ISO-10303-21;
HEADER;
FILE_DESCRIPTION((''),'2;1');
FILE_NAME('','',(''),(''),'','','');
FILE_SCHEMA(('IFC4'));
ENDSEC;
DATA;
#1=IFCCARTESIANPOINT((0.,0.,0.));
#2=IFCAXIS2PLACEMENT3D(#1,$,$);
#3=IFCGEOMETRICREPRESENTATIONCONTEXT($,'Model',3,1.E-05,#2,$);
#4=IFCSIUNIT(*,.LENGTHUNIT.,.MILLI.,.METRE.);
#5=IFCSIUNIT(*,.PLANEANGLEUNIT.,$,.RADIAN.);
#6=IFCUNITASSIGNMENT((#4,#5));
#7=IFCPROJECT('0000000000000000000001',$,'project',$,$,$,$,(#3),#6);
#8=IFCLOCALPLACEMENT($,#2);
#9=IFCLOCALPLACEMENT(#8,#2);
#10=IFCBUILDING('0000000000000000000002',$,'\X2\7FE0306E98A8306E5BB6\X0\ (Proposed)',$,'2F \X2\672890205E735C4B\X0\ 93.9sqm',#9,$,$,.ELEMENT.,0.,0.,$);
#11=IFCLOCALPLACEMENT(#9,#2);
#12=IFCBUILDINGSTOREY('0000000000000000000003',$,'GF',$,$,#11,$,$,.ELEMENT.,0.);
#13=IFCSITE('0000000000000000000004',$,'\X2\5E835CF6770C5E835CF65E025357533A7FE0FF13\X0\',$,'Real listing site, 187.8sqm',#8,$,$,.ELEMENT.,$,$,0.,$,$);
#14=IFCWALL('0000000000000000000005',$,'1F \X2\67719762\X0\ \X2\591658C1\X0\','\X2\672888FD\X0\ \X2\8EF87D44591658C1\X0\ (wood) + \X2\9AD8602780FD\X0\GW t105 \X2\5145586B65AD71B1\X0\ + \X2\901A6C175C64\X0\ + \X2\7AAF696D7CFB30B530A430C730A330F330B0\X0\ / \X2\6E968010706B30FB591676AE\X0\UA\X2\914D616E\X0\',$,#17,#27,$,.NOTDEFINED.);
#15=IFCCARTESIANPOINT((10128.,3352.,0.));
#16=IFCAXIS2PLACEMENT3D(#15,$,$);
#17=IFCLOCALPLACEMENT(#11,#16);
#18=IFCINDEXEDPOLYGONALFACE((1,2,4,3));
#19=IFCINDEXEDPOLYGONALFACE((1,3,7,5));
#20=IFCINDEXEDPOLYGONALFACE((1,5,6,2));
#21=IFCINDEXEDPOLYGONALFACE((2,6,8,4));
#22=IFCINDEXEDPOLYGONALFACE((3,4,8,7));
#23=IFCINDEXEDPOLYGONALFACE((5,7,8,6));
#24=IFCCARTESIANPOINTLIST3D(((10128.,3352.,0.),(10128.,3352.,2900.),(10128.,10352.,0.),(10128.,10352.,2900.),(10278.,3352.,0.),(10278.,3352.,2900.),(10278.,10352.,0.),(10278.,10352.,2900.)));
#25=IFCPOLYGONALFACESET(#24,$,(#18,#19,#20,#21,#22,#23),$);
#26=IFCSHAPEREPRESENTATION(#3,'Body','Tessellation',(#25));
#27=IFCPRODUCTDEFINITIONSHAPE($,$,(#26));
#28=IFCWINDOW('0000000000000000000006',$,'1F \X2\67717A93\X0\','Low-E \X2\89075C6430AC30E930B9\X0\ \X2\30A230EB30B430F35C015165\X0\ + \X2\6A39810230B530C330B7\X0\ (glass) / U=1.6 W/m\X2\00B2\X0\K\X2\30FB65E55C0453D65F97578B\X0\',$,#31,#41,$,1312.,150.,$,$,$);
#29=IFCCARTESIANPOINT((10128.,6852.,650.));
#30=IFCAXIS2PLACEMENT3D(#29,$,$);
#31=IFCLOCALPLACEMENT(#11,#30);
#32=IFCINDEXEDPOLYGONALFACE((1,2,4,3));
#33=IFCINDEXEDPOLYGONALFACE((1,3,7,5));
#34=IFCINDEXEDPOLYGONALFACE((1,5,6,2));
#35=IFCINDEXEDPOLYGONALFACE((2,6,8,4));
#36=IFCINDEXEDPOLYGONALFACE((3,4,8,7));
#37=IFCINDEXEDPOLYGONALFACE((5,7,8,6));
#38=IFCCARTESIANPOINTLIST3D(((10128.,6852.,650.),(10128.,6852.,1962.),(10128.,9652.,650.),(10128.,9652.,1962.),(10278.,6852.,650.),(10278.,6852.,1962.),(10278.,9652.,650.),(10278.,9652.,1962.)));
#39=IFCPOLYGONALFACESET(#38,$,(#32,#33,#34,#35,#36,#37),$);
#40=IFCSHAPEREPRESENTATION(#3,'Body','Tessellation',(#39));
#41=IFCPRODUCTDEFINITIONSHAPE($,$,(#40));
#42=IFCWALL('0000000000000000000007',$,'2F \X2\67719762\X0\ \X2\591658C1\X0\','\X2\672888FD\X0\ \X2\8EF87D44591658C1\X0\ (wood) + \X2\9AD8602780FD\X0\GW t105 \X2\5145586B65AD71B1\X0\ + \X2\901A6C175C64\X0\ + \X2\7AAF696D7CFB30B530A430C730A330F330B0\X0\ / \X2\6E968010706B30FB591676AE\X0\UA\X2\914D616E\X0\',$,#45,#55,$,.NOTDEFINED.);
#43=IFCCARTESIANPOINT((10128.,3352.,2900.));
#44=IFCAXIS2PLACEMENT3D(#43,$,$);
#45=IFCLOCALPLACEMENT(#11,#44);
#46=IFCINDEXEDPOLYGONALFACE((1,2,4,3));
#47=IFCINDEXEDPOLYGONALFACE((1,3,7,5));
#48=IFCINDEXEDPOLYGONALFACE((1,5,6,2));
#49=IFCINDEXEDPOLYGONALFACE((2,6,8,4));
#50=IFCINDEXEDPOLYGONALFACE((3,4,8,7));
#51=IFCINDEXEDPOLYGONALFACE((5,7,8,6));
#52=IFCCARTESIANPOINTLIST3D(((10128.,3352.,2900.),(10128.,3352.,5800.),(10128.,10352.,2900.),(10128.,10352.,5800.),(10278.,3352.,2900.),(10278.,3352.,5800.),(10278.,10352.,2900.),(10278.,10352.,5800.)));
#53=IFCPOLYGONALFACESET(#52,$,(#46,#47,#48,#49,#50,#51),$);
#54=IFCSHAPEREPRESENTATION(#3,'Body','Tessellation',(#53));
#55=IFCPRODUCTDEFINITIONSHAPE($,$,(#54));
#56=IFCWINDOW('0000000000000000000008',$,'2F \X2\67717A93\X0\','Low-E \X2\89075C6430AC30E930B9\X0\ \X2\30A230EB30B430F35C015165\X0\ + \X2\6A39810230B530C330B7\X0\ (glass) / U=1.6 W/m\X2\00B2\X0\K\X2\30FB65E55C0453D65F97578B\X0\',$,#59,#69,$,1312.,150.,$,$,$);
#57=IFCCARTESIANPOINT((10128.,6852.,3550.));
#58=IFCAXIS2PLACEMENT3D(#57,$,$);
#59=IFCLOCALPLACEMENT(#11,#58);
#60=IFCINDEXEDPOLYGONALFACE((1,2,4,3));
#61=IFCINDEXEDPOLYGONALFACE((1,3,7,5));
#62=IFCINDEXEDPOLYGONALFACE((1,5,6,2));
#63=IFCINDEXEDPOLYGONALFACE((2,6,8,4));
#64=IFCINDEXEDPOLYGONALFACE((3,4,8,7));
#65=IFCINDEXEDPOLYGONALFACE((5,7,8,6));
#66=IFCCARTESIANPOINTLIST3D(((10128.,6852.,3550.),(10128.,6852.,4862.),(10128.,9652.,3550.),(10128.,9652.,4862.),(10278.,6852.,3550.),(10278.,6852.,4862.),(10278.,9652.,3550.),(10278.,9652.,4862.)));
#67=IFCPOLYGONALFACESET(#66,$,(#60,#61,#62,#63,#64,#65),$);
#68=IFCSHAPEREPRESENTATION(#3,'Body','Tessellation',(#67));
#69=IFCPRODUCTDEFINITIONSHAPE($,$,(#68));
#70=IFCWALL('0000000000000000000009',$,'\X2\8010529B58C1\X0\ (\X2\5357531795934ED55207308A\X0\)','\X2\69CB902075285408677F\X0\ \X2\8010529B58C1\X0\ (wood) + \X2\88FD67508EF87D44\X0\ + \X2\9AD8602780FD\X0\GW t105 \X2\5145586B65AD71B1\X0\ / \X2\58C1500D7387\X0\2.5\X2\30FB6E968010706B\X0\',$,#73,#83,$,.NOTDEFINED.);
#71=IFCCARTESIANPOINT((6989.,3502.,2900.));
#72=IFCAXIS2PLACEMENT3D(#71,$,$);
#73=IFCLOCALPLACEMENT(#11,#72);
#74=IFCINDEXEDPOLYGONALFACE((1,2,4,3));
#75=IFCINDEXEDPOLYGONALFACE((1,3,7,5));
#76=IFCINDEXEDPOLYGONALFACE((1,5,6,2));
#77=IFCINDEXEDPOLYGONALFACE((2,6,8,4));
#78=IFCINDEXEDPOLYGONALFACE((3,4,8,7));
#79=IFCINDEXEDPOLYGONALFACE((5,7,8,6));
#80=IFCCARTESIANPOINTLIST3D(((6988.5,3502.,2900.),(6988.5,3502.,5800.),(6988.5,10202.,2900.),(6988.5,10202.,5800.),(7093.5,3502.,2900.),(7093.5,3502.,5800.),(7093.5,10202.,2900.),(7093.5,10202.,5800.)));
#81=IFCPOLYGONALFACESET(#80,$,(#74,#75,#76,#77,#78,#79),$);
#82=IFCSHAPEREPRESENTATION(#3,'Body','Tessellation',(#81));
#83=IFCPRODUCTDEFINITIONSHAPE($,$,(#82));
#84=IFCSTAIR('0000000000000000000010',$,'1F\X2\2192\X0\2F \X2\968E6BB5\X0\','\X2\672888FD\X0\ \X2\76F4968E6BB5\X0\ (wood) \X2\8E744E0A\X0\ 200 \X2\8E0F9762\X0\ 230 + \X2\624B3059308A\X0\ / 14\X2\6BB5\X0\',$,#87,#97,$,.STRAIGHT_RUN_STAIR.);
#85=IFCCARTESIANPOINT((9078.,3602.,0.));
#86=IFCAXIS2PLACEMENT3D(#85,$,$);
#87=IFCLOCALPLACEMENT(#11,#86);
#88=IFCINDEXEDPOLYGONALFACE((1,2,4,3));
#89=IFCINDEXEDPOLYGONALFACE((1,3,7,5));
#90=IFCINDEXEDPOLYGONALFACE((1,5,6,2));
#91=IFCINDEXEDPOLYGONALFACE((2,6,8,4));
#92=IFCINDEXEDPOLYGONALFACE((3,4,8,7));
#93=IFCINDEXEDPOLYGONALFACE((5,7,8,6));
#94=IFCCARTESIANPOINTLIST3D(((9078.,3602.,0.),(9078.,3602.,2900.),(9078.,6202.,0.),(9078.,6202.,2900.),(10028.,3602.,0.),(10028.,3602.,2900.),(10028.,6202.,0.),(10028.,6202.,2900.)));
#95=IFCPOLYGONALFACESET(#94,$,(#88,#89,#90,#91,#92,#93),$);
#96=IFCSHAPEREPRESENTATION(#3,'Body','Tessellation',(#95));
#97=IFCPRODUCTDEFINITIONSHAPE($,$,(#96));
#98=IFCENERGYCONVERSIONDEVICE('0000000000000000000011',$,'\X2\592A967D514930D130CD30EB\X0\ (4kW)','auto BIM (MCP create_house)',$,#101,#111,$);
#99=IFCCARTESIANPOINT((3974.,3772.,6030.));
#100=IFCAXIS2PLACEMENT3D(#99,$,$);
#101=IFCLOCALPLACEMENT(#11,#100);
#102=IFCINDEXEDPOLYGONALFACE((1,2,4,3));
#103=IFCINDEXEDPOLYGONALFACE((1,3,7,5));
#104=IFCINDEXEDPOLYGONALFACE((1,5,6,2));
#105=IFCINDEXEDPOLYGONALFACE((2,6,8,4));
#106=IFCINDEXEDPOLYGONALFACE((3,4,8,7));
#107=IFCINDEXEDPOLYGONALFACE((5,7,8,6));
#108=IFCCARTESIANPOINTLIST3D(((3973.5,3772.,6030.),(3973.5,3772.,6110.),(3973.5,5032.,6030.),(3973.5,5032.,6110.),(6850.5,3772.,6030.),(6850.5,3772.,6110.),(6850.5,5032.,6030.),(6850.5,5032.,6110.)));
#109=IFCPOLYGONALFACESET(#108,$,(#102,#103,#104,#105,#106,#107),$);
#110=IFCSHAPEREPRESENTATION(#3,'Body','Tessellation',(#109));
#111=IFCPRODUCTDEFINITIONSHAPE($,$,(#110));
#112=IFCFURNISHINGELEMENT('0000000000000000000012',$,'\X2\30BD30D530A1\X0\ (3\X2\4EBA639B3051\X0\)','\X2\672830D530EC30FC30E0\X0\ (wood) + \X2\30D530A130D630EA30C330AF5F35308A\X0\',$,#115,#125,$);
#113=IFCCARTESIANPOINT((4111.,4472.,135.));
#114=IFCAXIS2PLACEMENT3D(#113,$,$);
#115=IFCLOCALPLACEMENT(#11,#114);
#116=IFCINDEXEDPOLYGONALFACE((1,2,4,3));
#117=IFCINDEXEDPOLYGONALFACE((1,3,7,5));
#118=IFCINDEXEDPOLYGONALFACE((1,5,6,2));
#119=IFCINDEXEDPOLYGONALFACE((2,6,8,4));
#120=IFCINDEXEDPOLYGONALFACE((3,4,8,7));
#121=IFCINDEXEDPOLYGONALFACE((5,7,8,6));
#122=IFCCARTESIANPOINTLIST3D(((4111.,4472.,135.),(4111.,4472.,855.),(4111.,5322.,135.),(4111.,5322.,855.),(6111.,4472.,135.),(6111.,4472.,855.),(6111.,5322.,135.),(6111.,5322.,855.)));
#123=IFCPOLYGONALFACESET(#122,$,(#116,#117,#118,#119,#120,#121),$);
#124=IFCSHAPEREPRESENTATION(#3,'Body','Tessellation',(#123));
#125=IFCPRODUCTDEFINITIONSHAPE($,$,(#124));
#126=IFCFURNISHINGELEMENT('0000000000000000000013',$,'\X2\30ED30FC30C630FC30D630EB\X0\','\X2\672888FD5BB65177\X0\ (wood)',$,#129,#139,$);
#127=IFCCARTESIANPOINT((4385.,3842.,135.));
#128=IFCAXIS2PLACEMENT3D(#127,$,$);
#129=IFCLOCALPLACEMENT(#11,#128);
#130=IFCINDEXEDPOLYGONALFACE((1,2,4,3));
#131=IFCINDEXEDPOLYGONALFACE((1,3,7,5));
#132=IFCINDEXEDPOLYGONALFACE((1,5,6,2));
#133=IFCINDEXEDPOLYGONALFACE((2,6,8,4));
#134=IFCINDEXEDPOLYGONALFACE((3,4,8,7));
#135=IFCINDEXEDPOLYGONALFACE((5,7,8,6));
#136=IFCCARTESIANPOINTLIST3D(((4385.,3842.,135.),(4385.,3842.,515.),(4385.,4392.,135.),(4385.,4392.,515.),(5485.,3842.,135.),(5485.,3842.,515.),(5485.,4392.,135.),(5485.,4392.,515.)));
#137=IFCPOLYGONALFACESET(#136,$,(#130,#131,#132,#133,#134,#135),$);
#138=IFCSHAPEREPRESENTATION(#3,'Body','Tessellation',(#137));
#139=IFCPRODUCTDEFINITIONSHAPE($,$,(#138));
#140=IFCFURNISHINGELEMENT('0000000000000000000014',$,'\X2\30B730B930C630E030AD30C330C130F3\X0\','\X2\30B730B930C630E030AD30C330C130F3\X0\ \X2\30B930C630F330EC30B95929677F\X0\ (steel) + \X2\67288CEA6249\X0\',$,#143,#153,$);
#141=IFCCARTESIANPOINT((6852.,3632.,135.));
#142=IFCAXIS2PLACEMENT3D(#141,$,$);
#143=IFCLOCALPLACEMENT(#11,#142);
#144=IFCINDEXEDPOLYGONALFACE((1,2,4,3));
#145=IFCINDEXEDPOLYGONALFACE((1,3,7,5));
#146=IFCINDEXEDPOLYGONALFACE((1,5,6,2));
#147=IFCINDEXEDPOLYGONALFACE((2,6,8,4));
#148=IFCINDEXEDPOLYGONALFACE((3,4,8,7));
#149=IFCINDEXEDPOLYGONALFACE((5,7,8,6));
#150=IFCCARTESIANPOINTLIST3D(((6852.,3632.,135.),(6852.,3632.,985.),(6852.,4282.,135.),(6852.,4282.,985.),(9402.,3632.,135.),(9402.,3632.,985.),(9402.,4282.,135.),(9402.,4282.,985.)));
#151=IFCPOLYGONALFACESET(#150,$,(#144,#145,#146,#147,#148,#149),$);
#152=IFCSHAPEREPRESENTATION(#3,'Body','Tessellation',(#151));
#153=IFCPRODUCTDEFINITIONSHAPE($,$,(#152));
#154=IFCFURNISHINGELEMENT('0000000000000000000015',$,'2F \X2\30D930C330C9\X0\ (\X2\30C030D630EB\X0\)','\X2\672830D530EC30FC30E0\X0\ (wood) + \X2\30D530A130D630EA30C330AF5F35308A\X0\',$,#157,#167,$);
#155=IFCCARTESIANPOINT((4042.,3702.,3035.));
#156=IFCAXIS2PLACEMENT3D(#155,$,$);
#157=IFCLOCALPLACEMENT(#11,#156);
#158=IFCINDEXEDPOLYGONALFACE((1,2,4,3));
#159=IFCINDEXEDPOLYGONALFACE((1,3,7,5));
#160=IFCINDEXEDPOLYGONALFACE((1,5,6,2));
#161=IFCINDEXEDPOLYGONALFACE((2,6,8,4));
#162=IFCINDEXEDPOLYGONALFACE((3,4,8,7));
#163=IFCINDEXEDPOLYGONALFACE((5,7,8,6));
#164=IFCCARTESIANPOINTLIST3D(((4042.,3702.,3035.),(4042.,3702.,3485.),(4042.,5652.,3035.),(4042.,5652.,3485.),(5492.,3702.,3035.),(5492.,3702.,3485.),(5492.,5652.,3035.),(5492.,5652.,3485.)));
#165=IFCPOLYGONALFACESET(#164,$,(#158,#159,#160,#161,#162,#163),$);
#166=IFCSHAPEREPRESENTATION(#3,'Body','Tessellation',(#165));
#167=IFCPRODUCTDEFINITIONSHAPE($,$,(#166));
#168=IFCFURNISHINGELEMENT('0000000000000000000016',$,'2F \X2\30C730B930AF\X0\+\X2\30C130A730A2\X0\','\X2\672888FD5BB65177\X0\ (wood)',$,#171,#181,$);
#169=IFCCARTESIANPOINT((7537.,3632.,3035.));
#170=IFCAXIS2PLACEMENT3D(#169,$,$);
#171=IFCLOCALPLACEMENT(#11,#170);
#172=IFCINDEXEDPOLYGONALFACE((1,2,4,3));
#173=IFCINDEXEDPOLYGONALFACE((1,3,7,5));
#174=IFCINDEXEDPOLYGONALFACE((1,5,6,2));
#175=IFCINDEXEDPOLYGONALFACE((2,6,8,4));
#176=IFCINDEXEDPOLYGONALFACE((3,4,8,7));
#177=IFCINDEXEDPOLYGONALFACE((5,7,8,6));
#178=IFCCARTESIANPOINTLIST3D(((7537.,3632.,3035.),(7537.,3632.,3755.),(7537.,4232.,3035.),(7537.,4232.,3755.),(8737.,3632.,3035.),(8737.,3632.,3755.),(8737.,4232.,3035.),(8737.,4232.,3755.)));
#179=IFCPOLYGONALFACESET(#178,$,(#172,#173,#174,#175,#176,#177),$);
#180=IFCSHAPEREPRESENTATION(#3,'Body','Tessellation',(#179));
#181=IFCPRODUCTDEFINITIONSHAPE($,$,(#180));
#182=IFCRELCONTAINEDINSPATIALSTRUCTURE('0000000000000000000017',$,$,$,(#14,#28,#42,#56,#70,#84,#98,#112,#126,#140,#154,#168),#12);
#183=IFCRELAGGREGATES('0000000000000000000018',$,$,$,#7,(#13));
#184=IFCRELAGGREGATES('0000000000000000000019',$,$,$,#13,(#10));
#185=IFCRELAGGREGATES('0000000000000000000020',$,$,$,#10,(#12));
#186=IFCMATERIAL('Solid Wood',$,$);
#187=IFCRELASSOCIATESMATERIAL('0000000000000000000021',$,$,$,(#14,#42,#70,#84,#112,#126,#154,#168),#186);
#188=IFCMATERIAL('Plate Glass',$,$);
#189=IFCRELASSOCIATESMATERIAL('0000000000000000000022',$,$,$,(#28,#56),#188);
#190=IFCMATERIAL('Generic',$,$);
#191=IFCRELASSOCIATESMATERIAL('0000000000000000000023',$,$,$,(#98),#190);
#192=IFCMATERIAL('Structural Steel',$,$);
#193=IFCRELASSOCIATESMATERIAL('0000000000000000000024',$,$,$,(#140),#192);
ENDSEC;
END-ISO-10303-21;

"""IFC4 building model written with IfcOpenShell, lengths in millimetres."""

from ifc_helpers import new_model, si_unit, frame, frame_2d, origin, place, context, project, spatial, rectangle, extrude, material, element, fill, save


model = new_model("IFC4")

# Units and contexts
model_context = context("Model", 3, precision=1e-05, world=origin())
ifc_project = project(units=[si_unit("LENGTHUNIT", "METRE", prefix="MILLI"), si_unit("PLANEANGLEUNIT", "RADIAN")], contexts=[model_context])

# Site, building, storey
site_placement = place(None, origin())
site = spatial("IfcSite", under=ifc_project, at=site_placement, Name="広島県広島市南区翠３", ObjectType="Real listing site, 187.8sqm", CompositionType="ELEMENT", RefElevation=0.0)
building_placement = place(site_placement, origin())
building = spatial("IfcBuilding", under=site, at=building_placement, Name="翠の風の家 (Proposed)", ObjectType="2F 木造平屋 93.9sqm", CompositionType="ELEMENT", ElevationOfRefHeight=0.0, ElevationOfTerrain=0.0)
storey_placement = place(building_placement, origin())
storey = spatial("IfcBuildingStorey", under=building, at=storey_placement, Name="GF", CompositionType="ELEMENT", Elevation=0.0)

# Wall, opening, window
ifc_material_1 = material(Name="Solid Wood")
wall_1_placement = place(storey_placement, frame((10128.0, 3352.0, 0.0)))
wall_1 = element("IfcWall", 1, at=wall_1_placement, inside=storey, material=ifc_material_1, Name="1F 東面 外壁", Description="木製 軸組外壁 (wood) + 高性能GW t105 充填断熱 + 通気層 + 窯業系サイディング / 準耐火・外皮UA配慮", PredefinedType="NOTDEFINED", context=model_context, shape_type="SweptSolid", body=[
    extrude(rectangle(XDim=150.0, YDim=7000.0, at=frame_2d((75.0, 3500.0))), frame((10128.0, 3352.0, 0.0)), (0.0, 0.0, 1.0), 2900.0),
])
opening_1_placement = place(storey_placement, frame((10128.0, 6852.0, 650.0)))
opening_1 = element("IfcOpeningElement", 2, at=opening_1_placement, cuts=wall_1, PredefinedType="NOTDEFINED", context=model_context, shape_type="SweptSolid", body=[
    extrude(rectangle(XDim=150.0, YDim=2800.0, at=frame_2d((75.0, 1400.0))), frame((10128.0, 6852.0, 650.0)), (0.0, 0.0, 1.0), 1312.0),
])
ifc_material_2 = material(Name="Plate Glass")
window_1_placement = place(storey_placement, frame((10128.0, 6852.0, 650.0)))
window_1 = element("IfcWindow", 3, at=window_1_placement, inside=storey, material=ifc_material_2, Name="1F 東窓", Description="Low-E 複層ガラス アルゴン封入 + 樹脂サッシ (glass) / U=1.6 W/m²K・日射取得型", OverallHeight=1312.0, OverallWidth=150.0, context=model_context, shape_type="SweptSolid", body=[
    extrude(rectangle(XDim=150.0, YDim=2800.0, at=frame_2d((75.0, 1400.0))), frame((10128.0, 6852.0, 650.0)), (0.0, 0.0, 1.0), 1312.0),
])
fill(opening_1, window_1)

# Wall, opening, window
wall_2_placement = place(storey_placement, frame((10128.0, 3352.0, 2900.0)))
wall_2 = element("IfcWall", 4, at=wall_2_placement, inside=storey, material=ifc_material_1, Name="2F 東面 外壁", Description="木製 軸組外壁 (wood) + 高性能GW t105 充填断熱 + 通気層 + 窯業系サイディング / 準耐火・外皮UA配慮", PredefinedType="NOTDEFINED", context=model_context, shape_type="SweptSolid", body=[
    extrude(rectangle(XDim=150.0, YDim=7000.0, at=frame_2d((75.0, 3500.0))), frame((10128.0, 3352.0, 2900.0)), (0.0, 0.0, 1.0), 2900.0),
])
opening_2_placement = place(storey_placement, frame((10128.0, 6852.0, 3550.0)))
opening_2 = element("IfcOpeningElement", 5, at=opening_2_placement, cuts=wall_2, PredefinedType="NOTDEFINED", context=model_context, shape_type="SweptSolid", body=[
    extrude(rectangle(XDim=150.0, YDim=2800.0, at=frame_2d((75.0, 1400.0))), frame((10128.0, 6852.0, 3550.0)), (0.0, 0.0, 1.0), 1312.0),
])
window_2_placement = place(storey_placement, frame((10128.0, 6852.0, 3550.0)))
window_2 = element("IfcWindow", 6, at=window_2_placement, inside=storey, material=ifc_material_2, Name="2F 東窓", Description="Low-E 複層ガラス アルゴン封入 + 樹脂サッシ (glass) / U=1.6 W/m²K・日射取得型", OverallHeight=1312.0, OverallWidth=150.0, context=model_context, shape_type="SweptSolid", body=[
    extrude(rectangle(XDim=150.0, YDim=2800.0, at=frame_2d((75.0, 1400.0))), frame((10128.0, 6852.0, 3550.0)), (0.0, 0.0, 1.0), 1312.0),
])
fill(opening_2, window_2)

# Wall
wall_3_placement = place(storey_placement, frame((6989.0, 3502.0, 2900.0)))
element("IfcWall", 7, at=wall_3_placement, inside=storey, material=ifc_material_1, Name="耐力壁 (南北間仕切り)", Description="構造用合板 耐力壁 (wood) + 製材軸組 + 高性能GW t105 充填断熱 / 壁倍率2.5・準耐火", PredefinedType="NOTDEFINED", context=model_context, shape_type="SweptSolid", body=[
    extrude(rectangle(XDim=105.0, YDim=6700.0, at=frame_2d((52.0, 3350.0))), frame((6989.0, 3502.0, 2900.0)), (0.0, 0.0, 1.0), 2900.0),
])

# Stair
stair_placement = place(storey_placement, frame((9078.0, 3602.0, 0.0)))
element("IfcStair", 8, at=stair_placement, inside=storey, material=ifc_material_1, Name="1F→2F 階段", Description="木製 直階段 (wood) 蹴上 200 踏面 230 + 手すり / 14段", PredefinedType="STRAIGHT_RUN_STAIR", context=model_context, shape_type="SweptSolid", body=[
    extrude(rectangle(XDim=950.0, YDim=2600.0, at=frame_2d((475.0, 1300.0))), frame((9078.0, 3602.0, 0.0)), (0.0, 0.0, 1.0), 2900.0),
])

# Energy conversion device
ifc_material_3 = material(Name="Generic")
energy_conversion_device_placement = place(storey_placement, frame((3974.0, 3772.0, 6030.0)))
element("IfcEnergyConversionDevice", 9, at=energy_conversion_device_placement, inside=storey, material=ifc_material_3, Name="太陽光パネル (4kW)", Description="auto BIM (MCP create_house)", context=model_context, shape_type="SweptSolid", body=[
    extrude(rectangle(XDim=2877.0, YDim=1260.0, at=frame_2d((1438.0, 630.0))), frame((3974.0, 3772.0, 6030.0)), (0.0, 0.0, 1.0), 80.0),
])

# Furnishing elements
furnishing_1_placement = place(storey_placement, frame((4111.0, 4472.0, 135.0)))
element("IfcFurnishingElement", 10, at=furnishing_1_placement, inside=storey, material=ifc_material_1, Name="ソファ (3人掛け)", Description="木フレーム (wood) + ファブリック張り", context=model_context, shape_type="SweptSolid", body=[
    extrude(rectangle(XDim=2000.0, YDim=850.0, at=frame_2d((1000.0, 425.0))), frame((4111.0, 4472.0, 135.0)), (0.0, 0.0, 1.0), 720.0),
])
furnishing_2_placement = place(storey_placement, frame((4385.0, 3842.0, 135.0)))
element("IfcFurnishingElement", 11, at=furnishing_2_placement, inside=storey, material=ifc_material_1, Name="ローテーブル", Description="木製家具 (wood)", context=model_context, shape_type="SweptSolid", body=[
    extrude(rectangle(XDim=1100.0, YDim=550.0, at=frame_2d((550.0, 275.0))), frame((4385.0, 3842.0, 135.0)), (0.0, 0.0, 1.0), 380.0),
])
ifc_material_4 = material(Name="Structural Steel")
furnishing_3_placement = place(storey_placement, frame((6852.0, 3632.0, 135.0)))
element("IfcFurnishingElement", 12, at=furnishing_3_placement, inside=storey, material=ifc_material_4, Name="システムキッチン", Description="システムキッチン ステンレス天板 (steel) + 木質扉", context=model_context, shape_type="SweptSolid", body=[
    extrude(rectangle(XDim=2550.0, YDim=650.0, at=frame_2d((1275.0, 325.0))), frame((6852.0, 3632.0, 135.0)), (0.0, 0.0, 1.0), 850.0),
])
furnishing_4_placement = place(storey_placement, frame((4042.0, 3702.0, 3035.0)))
element("IfcFurnishingElement", 13, at=furnishing_4_placement, inside=storey, material=ifc_material_1, Name="2F ベッド (ダブル)", Description="木フレーム (wood) + ファブリック張り", context=model_context, shape_type="SweptSolid", body=[
    extrude(rectangle(XDim=1450.0, YDim=1950.0, at=frame_2d((725.0, 975.0))), frame((4042.0, 3702.0, 3035.0)), (0.0, 0.0, 1.0), 450.0),
])
furnishing_5_placement = place(storey_placement, frame((7537.0, 3632.0, 3035.0)))
element("IfcFurnishingElement", 14, at=furnishing_5_placement, inside=storey, material=ifc_material_1, Name="2F デスク+チェア", Description="木製家具 (wood)", context=model_context, shape_type="SweptSolid", body=[
    extrude(rectangle(XDim=1200.0, YDim=600.0, at=frame_2d((600.0, 300.0))), frame((7537.0, 3632.0, 3035.0)), (0.0, 0.0, 1.0), 720.0),
])

save(model, "model.ifc")
